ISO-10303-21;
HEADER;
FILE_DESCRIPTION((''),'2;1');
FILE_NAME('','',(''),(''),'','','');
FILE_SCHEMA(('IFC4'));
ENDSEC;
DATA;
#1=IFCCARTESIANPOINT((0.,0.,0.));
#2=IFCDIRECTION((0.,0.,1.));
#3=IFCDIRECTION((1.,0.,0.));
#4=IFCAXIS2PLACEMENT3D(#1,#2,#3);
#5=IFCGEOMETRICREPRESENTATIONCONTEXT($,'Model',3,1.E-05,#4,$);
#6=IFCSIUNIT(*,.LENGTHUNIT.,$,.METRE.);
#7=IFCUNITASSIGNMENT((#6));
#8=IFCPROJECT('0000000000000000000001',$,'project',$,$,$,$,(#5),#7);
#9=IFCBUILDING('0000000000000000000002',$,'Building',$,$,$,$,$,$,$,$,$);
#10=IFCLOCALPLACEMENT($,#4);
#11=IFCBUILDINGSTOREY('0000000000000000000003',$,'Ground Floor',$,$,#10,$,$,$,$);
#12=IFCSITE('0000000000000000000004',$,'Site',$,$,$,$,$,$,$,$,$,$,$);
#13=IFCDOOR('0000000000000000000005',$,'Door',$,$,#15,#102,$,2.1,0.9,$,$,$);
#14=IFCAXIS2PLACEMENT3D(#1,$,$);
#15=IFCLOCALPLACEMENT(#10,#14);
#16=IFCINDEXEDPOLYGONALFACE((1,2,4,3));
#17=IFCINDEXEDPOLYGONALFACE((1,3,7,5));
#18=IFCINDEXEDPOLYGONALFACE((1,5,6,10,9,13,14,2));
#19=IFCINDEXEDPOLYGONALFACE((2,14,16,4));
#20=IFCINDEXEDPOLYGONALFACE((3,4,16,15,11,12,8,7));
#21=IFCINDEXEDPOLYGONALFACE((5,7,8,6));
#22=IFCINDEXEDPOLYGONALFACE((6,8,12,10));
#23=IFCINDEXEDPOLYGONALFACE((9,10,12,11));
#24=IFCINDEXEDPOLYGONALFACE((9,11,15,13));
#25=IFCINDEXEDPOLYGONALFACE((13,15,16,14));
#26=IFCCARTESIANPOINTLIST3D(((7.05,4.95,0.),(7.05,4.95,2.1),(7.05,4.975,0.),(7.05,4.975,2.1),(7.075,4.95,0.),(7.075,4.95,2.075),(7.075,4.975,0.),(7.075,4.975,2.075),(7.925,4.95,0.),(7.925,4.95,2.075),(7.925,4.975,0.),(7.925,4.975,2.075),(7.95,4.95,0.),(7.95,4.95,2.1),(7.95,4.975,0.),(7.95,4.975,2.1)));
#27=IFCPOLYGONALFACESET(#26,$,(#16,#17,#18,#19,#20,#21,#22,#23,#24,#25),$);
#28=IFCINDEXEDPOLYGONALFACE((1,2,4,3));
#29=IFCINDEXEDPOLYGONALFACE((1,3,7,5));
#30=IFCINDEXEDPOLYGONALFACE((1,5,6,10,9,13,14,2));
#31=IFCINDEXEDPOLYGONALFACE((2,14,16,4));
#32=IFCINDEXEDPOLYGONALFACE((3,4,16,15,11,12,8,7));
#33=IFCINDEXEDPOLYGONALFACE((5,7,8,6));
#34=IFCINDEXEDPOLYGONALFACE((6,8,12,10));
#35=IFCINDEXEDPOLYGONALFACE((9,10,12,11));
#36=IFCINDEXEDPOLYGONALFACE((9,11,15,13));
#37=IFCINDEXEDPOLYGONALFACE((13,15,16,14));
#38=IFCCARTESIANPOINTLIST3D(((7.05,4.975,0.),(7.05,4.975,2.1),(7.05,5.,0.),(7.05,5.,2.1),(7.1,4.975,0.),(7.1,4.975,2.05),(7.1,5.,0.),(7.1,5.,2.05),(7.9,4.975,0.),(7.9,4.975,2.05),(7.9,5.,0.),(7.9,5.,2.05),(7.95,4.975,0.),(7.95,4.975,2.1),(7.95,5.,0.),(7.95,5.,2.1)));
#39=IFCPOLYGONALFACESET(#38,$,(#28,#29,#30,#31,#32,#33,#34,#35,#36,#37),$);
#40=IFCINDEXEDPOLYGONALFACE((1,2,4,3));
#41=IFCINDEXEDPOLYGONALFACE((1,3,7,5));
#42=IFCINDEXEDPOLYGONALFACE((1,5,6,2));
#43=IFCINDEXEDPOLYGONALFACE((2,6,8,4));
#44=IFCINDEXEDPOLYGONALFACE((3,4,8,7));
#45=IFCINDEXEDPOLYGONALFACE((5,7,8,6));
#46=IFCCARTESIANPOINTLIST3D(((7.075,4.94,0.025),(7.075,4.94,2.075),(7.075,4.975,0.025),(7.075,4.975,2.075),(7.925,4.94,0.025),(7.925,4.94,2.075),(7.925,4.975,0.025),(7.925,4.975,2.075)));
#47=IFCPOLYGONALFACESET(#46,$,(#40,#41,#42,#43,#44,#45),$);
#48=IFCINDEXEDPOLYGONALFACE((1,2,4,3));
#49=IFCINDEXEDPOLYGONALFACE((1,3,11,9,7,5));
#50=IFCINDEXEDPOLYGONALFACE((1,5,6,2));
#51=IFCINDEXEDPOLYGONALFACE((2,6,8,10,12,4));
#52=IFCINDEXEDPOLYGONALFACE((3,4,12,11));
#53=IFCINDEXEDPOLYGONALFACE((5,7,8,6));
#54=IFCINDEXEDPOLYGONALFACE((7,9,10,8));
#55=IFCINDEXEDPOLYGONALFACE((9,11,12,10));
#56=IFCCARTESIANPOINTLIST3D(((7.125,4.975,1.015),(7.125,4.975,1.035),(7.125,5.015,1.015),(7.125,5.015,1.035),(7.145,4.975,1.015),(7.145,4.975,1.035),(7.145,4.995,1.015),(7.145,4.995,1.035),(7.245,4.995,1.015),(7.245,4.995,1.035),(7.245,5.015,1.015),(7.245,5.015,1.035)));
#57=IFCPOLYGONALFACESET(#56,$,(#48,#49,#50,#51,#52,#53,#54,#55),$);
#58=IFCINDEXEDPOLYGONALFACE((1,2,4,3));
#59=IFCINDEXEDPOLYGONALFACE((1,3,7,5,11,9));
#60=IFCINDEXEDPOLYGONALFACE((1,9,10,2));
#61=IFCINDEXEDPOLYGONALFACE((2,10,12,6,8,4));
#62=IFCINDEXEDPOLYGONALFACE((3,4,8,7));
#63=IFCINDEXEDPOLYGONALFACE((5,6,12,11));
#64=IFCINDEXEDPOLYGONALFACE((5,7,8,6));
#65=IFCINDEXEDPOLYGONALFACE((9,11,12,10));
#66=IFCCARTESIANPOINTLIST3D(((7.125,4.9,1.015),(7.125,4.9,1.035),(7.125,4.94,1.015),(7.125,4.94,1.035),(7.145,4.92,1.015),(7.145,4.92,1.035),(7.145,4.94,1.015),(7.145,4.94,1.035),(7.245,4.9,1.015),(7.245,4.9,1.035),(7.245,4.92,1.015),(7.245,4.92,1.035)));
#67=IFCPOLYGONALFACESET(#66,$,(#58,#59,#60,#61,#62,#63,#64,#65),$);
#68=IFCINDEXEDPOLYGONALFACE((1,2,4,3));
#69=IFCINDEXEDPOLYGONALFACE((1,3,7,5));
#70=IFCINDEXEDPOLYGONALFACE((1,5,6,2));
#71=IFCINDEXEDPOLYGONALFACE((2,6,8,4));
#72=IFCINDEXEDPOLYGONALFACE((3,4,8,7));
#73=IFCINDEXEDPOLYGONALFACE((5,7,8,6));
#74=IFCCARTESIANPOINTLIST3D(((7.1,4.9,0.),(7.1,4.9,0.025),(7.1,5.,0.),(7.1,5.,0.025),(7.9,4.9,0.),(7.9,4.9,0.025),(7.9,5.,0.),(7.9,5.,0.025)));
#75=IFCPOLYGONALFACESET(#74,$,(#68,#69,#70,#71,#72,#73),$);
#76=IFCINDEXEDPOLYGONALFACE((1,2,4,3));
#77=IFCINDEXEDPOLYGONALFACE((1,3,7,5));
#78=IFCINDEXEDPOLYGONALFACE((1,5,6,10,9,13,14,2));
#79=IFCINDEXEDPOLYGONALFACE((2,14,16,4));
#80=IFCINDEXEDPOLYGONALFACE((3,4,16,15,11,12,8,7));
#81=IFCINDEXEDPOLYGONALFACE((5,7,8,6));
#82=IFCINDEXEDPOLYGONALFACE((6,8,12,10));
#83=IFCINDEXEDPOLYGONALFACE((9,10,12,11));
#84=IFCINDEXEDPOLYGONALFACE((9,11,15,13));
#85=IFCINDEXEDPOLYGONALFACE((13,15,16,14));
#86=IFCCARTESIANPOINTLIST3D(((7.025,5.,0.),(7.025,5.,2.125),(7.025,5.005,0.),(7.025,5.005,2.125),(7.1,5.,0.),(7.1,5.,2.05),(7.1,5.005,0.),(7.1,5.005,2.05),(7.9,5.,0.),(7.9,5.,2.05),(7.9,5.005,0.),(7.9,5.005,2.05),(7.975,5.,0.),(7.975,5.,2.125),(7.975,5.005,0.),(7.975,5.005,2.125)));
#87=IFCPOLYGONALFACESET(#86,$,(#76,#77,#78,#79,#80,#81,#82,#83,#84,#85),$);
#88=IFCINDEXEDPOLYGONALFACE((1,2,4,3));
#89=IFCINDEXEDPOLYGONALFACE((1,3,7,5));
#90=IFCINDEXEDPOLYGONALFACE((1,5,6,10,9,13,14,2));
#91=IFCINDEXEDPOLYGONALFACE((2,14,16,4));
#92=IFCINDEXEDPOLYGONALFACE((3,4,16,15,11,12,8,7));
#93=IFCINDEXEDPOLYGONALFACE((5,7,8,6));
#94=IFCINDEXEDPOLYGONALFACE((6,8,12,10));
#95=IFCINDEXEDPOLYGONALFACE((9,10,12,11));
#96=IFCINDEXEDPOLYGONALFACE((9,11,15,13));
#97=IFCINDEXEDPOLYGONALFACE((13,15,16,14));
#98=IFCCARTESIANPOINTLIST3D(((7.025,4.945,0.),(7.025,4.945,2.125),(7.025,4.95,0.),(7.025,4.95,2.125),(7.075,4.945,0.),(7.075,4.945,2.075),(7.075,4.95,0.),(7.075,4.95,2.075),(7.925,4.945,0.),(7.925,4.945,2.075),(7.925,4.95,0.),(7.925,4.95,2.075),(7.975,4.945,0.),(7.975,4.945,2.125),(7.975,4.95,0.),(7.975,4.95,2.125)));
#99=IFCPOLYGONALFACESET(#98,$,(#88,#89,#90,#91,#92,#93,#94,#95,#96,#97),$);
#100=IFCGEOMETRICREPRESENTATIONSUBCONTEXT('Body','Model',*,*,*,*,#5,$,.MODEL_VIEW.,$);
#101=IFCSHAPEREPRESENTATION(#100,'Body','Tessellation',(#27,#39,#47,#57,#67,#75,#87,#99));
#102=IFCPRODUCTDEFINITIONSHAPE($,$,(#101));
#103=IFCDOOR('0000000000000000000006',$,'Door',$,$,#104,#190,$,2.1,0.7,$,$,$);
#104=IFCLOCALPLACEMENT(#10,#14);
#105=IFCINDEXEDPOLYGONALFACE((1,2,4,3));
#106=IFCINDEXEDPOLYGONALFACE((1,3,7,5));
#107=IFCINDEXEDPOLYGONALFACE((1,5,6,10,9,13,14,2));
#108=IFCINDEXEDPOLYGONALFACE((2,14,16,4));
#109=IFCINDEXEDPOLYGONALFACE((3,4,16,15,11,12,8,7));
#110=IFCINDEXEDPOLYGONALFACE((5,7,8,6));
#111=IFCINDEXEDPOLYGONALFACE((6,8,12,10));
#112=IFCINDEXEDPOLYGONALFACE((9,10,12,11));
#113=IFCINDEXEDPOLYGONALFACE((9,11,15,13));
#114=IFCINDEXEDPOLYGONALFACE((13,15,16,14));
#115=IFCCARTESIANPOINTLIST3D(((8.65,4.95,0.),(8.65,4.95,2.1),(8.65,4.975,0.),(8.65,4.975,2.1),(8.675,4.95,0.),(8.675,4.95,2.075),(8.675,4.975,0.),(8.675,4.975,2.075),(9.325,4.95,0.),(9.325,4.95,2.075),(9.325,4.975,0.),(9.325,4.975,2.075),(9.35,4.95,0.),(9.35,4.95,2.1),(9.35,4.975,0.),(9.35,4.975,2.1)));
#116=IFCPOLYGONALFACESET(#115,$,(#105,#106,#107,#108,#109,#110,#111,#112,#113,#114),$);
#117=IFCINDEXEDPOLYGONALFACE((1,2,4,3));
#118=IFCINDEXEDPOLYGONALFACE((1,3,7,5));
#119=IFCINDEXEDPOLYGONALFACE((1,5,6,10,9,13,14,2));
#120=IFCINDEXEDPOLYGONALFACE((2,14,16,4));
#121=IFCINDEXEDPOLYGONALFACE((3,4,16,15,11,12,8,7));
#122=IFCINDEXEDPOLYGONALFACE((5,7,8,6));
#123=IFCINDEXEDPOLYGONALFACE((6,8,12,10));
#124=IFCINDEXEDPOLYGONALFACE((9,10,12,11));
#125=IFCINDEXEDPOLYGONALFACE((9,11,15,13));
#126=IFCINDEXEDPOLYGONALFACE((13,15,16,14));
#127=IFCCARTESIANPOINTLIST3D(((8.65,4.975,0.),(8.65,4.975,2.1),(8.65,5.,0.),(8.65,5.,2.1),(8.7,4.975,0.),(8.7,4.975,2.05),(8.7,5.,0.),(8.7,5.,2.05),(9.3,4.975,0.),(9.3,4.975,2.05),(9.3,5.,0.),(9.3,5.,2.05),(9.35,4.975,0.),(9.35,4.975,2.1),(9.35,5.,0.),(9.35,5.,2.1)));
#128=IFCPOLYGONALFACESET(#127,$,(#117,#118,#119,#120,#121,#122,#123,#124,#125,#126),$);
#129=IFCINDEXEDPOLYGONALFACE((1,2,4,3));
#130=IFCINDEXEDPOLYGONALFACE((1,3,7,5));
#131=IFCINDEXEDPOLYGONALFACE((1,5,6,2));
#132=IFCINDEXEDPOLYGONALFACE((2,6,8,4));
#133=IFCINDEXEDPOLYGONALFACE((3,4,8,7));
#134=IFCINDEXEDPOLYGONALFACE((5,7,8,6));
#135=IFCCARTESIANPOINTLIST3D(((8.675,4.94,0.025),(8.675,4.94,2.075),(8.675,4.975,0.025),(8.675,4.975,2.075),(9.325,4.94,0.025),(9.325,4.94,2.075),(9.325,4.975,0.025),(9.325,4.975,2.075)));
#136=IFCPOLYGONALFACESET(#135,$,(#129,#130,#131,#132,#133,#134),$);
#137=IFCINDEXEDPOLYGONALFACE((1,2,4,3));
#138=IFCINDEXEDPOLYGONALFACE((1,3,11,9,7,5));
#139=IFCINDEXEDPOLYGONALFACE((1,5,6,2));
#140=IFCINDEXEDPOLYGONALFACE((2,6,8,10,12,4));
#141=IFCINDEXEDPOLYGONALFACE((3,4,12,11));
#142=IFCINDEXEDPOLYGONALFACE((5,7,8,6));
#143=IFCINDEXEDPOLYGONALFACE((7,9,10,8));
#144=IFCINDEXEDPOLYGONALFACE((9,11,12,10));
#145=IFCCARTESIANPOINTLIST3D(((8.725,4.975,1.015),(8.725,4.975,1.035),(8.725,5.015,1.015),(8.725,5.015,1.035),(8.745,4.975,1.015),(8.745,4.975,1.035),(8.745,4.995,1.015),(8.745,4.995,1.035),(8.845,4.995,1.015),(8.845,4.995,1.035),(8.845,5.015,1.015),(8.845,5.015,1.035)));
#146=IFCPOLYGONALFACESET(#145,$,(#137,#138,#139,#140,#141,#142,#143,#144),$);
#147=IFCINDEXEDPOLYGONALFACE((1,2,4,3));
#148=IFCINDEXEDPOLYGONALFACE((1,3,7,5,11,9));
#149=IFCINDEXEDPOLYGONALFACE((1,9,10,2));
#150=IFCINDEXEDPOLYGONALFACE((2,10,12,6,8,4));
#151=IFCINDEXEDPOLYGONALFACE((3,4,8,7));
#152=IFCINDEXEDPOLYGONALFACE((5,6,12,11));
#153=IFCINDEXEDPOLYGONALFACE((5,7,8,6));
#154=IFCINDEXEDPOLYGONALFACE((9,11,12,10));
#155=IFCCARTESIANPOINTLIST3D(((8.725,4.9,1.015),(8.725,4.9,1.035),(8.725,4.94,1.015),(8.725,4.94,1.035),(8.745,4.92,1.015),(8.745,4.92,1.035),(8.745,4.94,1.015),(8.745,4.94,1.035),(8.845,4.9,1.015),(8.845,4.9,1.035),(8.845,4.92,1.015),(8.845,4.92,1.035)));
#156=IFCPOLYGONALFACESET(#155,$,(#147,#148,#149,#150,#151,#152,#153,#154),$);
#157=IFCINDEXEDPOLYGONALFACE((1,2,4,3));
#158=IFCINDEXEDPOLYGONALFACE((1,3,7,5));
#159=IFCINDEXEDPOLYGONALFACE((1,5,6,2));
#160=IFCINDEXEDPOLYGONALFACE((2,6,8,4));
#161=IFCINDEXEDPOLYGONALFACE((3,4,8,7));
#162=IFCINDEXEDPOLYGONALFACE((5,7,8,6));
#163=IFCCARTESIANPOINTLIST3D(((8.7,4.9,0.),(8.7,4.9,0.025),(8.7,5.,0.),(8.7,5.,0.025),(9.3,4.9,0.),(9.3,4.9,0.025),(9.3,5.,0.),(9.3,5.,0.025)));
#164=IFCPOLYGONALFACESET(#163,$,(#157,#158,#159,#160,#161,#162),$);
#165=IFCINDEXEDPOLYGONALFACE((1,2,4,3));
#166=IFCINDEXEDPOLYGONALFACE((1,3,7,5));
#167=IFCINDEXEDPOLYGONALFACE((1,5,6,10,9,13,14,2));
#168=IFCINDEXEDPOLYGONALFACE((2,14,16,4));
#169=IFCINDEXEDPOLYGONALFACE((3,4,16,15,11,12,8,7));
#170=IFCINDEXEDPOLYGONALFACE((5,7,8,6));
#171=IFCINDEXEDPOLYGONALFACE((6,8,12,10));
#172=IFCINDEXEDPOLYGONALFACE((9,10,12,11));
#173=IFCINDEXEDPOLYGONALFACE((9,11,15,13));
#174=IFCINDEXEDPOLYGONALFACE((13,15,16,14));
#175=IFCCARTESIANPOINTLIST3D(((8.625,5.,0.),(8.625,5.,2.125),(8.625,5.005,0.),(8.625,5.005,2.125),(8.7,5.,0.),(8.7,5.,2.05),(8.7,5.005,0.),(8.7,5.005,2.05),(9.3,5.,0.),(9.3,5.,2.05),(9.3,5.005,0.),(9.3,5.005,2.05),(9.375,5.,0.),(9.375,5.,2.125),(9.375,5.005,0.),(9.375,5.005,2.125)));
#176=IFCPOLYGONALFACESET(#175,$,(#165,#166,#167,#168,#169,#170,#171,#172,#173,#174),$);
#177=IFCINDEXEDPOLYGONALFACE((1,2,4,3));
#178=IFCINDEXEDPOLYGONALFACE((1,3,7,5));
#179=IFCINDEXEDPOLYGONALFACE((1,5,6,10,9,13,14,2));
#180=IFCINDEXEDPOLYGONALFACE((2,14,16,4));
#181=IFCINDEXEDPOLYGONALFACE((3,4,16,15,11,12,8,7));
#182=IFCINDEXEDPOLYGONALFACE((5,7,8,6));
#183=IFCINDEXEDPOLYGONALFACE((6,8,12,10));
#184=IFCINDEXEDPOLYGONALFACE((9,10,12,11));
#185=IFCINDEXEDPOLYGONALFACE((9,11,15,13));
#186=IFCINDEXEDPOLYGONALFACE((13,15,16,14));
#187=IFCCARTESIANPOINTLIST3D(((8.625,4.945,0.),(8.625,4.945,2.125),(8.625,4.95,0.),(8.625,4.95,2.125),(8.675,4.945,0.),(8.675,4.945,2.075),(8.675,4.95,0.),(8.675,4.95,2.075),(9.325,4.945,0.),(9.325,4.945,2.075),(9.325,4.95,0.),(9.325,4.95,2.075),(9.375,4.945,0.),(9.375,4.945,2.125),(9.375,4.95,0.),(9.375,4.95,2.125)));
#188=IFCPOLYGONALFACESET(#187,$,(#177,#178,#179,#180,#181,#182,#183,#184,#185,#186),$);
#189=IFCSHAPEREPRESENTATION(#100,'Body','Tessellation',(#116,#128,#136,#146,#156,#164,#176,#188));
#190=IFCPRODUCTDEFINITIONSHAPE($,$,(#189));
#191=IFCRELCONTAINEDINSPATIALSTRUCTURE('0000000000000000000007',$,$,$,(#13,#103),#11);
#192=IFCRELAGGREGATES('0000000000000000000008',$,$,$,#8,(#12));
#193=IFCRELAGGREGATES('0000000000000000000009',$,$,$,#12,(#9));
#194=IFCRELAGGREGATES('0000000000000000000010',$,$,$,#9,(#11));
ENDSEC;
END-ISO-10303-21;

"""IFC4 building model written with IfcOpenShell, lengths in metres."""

from ifc_helpers import new_model, si_unit, frame, origin_with_axes, place, context, subcontext, project, spatial, line, indexed_curve, outline, extrude, element, save


model = new_model("IFC4")

# Units and contexts
model_context = context("Model", 3, precision=1e-05, world=origin_with_axes())
body_context = subcontext(model_context, "Body", "Model", "MODEL_VIEW")
ifc_project = project(units=[si_unit("LENGTHUNIT", "METRE")], contexts=[model_context])

# Site, building, storey
site = spatial("IfcSite", under=ifc_project, Name="Site")
building = spatial("IfcBuilding", under=site, Name="Building")
storey_placement = place(None, origin_with_axes())
storey = spatial("IfcBuildingStorey", under=building, at=storey_placement, Name="Ground Floor")

# Doors
door_1_placement = place(storey_placement, frame((7.95, 5.0, 0.0), z_axis=(0.0, 0.0, 1.0), x_axis=(-1.0, 0.0, 0.0)))
element("IfcDoor", 1, at=door_1_placement, inside=storey, Name="Door", OverallHeight=2.1, OverallWidth=0.9, context=body_context, shape_type="SweptSolid", body=[
    extrude(outline(indexed_curve([(0.0, 0.0), (0.0, 2.1), (0.9, 2.1), (0.9, 0.0), (0.875, 0.0), (0.875, 2.075), (0.025, 2.075), (0.025, 0.0)], segments=[line(1, 2, 3, 4, 5, 6, 7, 8, 1)])), frame((0.0, 0.025, 0.0), z_axis=(0.0, -1.0, 0.0), x_axis=(1.0, 0.0, 0.0)), (0.0, 0.0, -1.0), 0.025),
    extrude(outline(indexed_curve([(0.0, 0.0), (0.0, 2.1), (0.9, 2.1), (0.9, 0.0), (0.85, 0.0), (0.85, 2.05), (0.05, 2.05), (0.05, 0.0)], segments=[line(1, 2, 3, 4, 5, 6, 7, 8, 1)])), frame((0.0, 0.0, 0.0), z_axis=(0.0, -1.0, 0.0), x_axis=(1.0, 0.0, 0.0)), (0.0, 0.0, -1.0), 0.025),
    extrude(outline(indexed_curve([(0.0, 0.0), (0.85, 0.0), (0.85, 0.035), (0.0, 0.035)], segments=[line(1, 2, 3, 4, 1)])), frame((0.025, 0.025, 0.025), z_axis=(0.0, 0.0, 1.0), x_axis=(1.0, 0.0, 0.0)), (0.0, 0.0, 1.0), 2.05),
    extrude(outline(indexed_curve([(0.0, 0.0), (0.0, -0.04), (-0.12, -0.04), (-0.12, -0.02), (-0.02, -0.02), (-0.02, 0.0)], segments=[line(1, 2, 3, 4, 5, 6, 1)])), frame((0.825, 0.025, 1.015), z_axis=(0.0, 0.0, 1.0), x_axis=(1.0, 0.0, 0.0)), (0.0, 0.0, 1.0), 0.02),
    extrude(outline(indexed_curve([(0.0, 0.0), (0.0, 0.04), (-0.12, 0.04), (-0.12, 0.02), (-0.02, 0.02), (-0.02, 0.0)], segments=[line(1, 2, 3, 4, 5, 6, 1)])), frame((0.825, 0.06, 1.015), z_axis=(0.0, 0.0, 1.0), x_axis=(1.0, 0.0, 0.0)), (0.0, 0.0, 1.0), 0.02),
    extrude(outline(indexed_curve([(0.0, 0.0), (0.8, 0.0), (0.8, 0.1), (0.0, 0.1)], segments=[line(1, 2, 3, 4, 1)])), frame((0.05, 0.0, 0.0), z_axis=(0.0, 0.0, 1.0), x_axis=(1.0, 0.0, 0.0)), (0.0, 0.0, 1.0), 0.025),
    extrude(outline(indexed_curve([(0.0, 0.0), (0.0, 2.125), (0.95, 2.125), (0.95, 0.0), (0.875, 0.0), (0.875, 2.05), (0.075, 2.05), (0.075, 0.0)], segments=[line(1, 2, 3, 4, 5, 6, 7, 8, 1)])), frame((-0.025, -0.005, 0.0), z_axis=(0.0, -1.0, 0.0), x_axis=(1.0, 0.0, 0.0)), (0.0, 0.0, -1.0), 0.005),
    extrude(outline(indexed_curve([(0.0, 0.0), (0.0, 2.125), (0.95, 2.125), (0.95, 0.0), (0.9, 0.0), (0.9, 2.075), (0.05, 2.075), (0.05, 0.0)], segments=[line(1, 2, 3, 4, 5, 6, 7, 8, 1)])), frame((-0.025, 0.05, 0.0), z_axis=(0.0, -1.0, 0.0), x_axis=(1.0, 0.0, 0.0)), (0.0, 0.0, -1.0), 0.005),
])
door_2_placement = place(storey_placement, frame((9.35, 5.0, 0.0), z_axis=(0.0, 0.0, 1.0), x_axis=(-1.0, 0.0, 0.0)))
element("IfcDoor", 2, at=door_2_placement, inside=storey, Name="Door", OverallHeight=2.1, OverallWidth=0.7, context=body_context, shape_type="SweptSolid", body=[
    extrude(outline(indexed_curve([(0.0, 0.0), (0.0, 2.1), (0.7, 2.1), (0.7, 0.0), (0.675, 0.0), (0.675, 2.075), (0.025, 2.075), (0.025, 0.0)], segments=[line(1, 2, 3, 4, 5, 6, 7, 8, 1)])), frame((0.0, 0.025, 0.0), z_axis=(0.0, -1.0, 0.0), x_axis=(1.0, 0.0, 0.0)), (0.0, 0.0, -1.0), 0.025),
    extrude(outline(indexed_curve([(0.0, 0.0), (0.0, 2.1), (0.7, 2.1), (0.7, 0.0), (0.65, 0.0), (0.65, 2.05), (0.05, 2.05), (0.05, 0.0)], segments=[line(1, 2, 3, 4, 5, 6, 7, 8, 1)])), frame((0.0, 0.0, 0.0), z_axis=(0.0, -1.0, 0.0), x_axis=(1.0, 0.0, 0.0)), (0.0, 0.0, -1.0), 0.025),
    extrude(outline(indexed_curve([(0.0, 0.0), (0.65, 0.0), (0.65, 0.035), (0.0, 0.035)], segments=[line(1, 2, 3, 4, 1)])), frame((0.025, 0.025, 0.025), z_axis=(0.0, 0.0, 1.0), x_axis=(1.0, 0.0, 0.0)), (0.0, 0.0, 1.0), 2.05),
    extrude(outline(indexed_curve([(0.0, 0.0), (0.0, -0.04), (-0.12, -0.04), (-0.12, -0.02), (-0.02, -0.02), (-0.02, 0.0)], segments=[line(1, 2, 3, 4, 5, 6, 1)])), frame((0.625, 0.025, 1.015), z_axis=(0.0, 0.0, 1.0), x_axis=(1.0, 0.0, 0.0)), (0.0, 0.0, 1.0), 0.02),
    extrude(outline(indexed_curve([(0.0, 0.0), (0.0, 0.04), (-0.12, 0.04), (-0.12, 0.02), (-0.02, 0.02), (-0.02, 0.0)], segments=[line(1, 2, 3, 4, 5, 6, 1)])), frame((0.625, 0.06, 1.015), z_axis=(0.0, 0.0, 1.0), x_axis=(1.0, 0.0, 0.0)), (0.0, 0.0, 1.0), 0.02),
    extrude(outline(indexed_curve([(0.0, 0.0), (0.6, 0.0), (0.6, 0.1), (0.0, 0.1)], segments=[line(1, 2, 3, 4, 1)])), frame((0.05, 0.0, 0.0), z_axis=(0.0, 0.0, 1.0), x_axis=(1.0, 0.0, 0.0)), (0.0, 0.0, 1.0), 0.025),
    extrude(outline(indexed_curve([(0.0, 0.0), (0.0, 2.125), (0.75, 2.125), (0.75, 0.0), (0.675, 0.0), (0.675, 2.05), (0.075, 2.05), (0.075, 0.0)], segments=[line(1, 2, 3, 4, 5, 6, 7, 8, 1)])), frame((-0.025, -0.005, 0.0), z_axis=(0.0, -1.0, 0.0), x_axis=(1.0, 0.0, 0.0)), (0.0, 0.0, -1.0), 0.005),
    extrude(outline(indexed_curve([(0.0, 0.0), (0.0, 2.125), (0.75, 2.125), (0.75, 0.0), (0.7, 0.0), (0.7, 2.075), (0.05, 2.075), (0.05, 0.0)], segments=[line(1, 2, 3, 4, 5, 6, 7, 8, 1)])), frame((-0.025, 0.05, 0.0), z_axis=(0.0, -1.0, 0.0), x_axis=(1.0, 0.0, 0.0)), (0.0, 0.0, -1.0), 0.005),
])

save(model, "model.ifc")
